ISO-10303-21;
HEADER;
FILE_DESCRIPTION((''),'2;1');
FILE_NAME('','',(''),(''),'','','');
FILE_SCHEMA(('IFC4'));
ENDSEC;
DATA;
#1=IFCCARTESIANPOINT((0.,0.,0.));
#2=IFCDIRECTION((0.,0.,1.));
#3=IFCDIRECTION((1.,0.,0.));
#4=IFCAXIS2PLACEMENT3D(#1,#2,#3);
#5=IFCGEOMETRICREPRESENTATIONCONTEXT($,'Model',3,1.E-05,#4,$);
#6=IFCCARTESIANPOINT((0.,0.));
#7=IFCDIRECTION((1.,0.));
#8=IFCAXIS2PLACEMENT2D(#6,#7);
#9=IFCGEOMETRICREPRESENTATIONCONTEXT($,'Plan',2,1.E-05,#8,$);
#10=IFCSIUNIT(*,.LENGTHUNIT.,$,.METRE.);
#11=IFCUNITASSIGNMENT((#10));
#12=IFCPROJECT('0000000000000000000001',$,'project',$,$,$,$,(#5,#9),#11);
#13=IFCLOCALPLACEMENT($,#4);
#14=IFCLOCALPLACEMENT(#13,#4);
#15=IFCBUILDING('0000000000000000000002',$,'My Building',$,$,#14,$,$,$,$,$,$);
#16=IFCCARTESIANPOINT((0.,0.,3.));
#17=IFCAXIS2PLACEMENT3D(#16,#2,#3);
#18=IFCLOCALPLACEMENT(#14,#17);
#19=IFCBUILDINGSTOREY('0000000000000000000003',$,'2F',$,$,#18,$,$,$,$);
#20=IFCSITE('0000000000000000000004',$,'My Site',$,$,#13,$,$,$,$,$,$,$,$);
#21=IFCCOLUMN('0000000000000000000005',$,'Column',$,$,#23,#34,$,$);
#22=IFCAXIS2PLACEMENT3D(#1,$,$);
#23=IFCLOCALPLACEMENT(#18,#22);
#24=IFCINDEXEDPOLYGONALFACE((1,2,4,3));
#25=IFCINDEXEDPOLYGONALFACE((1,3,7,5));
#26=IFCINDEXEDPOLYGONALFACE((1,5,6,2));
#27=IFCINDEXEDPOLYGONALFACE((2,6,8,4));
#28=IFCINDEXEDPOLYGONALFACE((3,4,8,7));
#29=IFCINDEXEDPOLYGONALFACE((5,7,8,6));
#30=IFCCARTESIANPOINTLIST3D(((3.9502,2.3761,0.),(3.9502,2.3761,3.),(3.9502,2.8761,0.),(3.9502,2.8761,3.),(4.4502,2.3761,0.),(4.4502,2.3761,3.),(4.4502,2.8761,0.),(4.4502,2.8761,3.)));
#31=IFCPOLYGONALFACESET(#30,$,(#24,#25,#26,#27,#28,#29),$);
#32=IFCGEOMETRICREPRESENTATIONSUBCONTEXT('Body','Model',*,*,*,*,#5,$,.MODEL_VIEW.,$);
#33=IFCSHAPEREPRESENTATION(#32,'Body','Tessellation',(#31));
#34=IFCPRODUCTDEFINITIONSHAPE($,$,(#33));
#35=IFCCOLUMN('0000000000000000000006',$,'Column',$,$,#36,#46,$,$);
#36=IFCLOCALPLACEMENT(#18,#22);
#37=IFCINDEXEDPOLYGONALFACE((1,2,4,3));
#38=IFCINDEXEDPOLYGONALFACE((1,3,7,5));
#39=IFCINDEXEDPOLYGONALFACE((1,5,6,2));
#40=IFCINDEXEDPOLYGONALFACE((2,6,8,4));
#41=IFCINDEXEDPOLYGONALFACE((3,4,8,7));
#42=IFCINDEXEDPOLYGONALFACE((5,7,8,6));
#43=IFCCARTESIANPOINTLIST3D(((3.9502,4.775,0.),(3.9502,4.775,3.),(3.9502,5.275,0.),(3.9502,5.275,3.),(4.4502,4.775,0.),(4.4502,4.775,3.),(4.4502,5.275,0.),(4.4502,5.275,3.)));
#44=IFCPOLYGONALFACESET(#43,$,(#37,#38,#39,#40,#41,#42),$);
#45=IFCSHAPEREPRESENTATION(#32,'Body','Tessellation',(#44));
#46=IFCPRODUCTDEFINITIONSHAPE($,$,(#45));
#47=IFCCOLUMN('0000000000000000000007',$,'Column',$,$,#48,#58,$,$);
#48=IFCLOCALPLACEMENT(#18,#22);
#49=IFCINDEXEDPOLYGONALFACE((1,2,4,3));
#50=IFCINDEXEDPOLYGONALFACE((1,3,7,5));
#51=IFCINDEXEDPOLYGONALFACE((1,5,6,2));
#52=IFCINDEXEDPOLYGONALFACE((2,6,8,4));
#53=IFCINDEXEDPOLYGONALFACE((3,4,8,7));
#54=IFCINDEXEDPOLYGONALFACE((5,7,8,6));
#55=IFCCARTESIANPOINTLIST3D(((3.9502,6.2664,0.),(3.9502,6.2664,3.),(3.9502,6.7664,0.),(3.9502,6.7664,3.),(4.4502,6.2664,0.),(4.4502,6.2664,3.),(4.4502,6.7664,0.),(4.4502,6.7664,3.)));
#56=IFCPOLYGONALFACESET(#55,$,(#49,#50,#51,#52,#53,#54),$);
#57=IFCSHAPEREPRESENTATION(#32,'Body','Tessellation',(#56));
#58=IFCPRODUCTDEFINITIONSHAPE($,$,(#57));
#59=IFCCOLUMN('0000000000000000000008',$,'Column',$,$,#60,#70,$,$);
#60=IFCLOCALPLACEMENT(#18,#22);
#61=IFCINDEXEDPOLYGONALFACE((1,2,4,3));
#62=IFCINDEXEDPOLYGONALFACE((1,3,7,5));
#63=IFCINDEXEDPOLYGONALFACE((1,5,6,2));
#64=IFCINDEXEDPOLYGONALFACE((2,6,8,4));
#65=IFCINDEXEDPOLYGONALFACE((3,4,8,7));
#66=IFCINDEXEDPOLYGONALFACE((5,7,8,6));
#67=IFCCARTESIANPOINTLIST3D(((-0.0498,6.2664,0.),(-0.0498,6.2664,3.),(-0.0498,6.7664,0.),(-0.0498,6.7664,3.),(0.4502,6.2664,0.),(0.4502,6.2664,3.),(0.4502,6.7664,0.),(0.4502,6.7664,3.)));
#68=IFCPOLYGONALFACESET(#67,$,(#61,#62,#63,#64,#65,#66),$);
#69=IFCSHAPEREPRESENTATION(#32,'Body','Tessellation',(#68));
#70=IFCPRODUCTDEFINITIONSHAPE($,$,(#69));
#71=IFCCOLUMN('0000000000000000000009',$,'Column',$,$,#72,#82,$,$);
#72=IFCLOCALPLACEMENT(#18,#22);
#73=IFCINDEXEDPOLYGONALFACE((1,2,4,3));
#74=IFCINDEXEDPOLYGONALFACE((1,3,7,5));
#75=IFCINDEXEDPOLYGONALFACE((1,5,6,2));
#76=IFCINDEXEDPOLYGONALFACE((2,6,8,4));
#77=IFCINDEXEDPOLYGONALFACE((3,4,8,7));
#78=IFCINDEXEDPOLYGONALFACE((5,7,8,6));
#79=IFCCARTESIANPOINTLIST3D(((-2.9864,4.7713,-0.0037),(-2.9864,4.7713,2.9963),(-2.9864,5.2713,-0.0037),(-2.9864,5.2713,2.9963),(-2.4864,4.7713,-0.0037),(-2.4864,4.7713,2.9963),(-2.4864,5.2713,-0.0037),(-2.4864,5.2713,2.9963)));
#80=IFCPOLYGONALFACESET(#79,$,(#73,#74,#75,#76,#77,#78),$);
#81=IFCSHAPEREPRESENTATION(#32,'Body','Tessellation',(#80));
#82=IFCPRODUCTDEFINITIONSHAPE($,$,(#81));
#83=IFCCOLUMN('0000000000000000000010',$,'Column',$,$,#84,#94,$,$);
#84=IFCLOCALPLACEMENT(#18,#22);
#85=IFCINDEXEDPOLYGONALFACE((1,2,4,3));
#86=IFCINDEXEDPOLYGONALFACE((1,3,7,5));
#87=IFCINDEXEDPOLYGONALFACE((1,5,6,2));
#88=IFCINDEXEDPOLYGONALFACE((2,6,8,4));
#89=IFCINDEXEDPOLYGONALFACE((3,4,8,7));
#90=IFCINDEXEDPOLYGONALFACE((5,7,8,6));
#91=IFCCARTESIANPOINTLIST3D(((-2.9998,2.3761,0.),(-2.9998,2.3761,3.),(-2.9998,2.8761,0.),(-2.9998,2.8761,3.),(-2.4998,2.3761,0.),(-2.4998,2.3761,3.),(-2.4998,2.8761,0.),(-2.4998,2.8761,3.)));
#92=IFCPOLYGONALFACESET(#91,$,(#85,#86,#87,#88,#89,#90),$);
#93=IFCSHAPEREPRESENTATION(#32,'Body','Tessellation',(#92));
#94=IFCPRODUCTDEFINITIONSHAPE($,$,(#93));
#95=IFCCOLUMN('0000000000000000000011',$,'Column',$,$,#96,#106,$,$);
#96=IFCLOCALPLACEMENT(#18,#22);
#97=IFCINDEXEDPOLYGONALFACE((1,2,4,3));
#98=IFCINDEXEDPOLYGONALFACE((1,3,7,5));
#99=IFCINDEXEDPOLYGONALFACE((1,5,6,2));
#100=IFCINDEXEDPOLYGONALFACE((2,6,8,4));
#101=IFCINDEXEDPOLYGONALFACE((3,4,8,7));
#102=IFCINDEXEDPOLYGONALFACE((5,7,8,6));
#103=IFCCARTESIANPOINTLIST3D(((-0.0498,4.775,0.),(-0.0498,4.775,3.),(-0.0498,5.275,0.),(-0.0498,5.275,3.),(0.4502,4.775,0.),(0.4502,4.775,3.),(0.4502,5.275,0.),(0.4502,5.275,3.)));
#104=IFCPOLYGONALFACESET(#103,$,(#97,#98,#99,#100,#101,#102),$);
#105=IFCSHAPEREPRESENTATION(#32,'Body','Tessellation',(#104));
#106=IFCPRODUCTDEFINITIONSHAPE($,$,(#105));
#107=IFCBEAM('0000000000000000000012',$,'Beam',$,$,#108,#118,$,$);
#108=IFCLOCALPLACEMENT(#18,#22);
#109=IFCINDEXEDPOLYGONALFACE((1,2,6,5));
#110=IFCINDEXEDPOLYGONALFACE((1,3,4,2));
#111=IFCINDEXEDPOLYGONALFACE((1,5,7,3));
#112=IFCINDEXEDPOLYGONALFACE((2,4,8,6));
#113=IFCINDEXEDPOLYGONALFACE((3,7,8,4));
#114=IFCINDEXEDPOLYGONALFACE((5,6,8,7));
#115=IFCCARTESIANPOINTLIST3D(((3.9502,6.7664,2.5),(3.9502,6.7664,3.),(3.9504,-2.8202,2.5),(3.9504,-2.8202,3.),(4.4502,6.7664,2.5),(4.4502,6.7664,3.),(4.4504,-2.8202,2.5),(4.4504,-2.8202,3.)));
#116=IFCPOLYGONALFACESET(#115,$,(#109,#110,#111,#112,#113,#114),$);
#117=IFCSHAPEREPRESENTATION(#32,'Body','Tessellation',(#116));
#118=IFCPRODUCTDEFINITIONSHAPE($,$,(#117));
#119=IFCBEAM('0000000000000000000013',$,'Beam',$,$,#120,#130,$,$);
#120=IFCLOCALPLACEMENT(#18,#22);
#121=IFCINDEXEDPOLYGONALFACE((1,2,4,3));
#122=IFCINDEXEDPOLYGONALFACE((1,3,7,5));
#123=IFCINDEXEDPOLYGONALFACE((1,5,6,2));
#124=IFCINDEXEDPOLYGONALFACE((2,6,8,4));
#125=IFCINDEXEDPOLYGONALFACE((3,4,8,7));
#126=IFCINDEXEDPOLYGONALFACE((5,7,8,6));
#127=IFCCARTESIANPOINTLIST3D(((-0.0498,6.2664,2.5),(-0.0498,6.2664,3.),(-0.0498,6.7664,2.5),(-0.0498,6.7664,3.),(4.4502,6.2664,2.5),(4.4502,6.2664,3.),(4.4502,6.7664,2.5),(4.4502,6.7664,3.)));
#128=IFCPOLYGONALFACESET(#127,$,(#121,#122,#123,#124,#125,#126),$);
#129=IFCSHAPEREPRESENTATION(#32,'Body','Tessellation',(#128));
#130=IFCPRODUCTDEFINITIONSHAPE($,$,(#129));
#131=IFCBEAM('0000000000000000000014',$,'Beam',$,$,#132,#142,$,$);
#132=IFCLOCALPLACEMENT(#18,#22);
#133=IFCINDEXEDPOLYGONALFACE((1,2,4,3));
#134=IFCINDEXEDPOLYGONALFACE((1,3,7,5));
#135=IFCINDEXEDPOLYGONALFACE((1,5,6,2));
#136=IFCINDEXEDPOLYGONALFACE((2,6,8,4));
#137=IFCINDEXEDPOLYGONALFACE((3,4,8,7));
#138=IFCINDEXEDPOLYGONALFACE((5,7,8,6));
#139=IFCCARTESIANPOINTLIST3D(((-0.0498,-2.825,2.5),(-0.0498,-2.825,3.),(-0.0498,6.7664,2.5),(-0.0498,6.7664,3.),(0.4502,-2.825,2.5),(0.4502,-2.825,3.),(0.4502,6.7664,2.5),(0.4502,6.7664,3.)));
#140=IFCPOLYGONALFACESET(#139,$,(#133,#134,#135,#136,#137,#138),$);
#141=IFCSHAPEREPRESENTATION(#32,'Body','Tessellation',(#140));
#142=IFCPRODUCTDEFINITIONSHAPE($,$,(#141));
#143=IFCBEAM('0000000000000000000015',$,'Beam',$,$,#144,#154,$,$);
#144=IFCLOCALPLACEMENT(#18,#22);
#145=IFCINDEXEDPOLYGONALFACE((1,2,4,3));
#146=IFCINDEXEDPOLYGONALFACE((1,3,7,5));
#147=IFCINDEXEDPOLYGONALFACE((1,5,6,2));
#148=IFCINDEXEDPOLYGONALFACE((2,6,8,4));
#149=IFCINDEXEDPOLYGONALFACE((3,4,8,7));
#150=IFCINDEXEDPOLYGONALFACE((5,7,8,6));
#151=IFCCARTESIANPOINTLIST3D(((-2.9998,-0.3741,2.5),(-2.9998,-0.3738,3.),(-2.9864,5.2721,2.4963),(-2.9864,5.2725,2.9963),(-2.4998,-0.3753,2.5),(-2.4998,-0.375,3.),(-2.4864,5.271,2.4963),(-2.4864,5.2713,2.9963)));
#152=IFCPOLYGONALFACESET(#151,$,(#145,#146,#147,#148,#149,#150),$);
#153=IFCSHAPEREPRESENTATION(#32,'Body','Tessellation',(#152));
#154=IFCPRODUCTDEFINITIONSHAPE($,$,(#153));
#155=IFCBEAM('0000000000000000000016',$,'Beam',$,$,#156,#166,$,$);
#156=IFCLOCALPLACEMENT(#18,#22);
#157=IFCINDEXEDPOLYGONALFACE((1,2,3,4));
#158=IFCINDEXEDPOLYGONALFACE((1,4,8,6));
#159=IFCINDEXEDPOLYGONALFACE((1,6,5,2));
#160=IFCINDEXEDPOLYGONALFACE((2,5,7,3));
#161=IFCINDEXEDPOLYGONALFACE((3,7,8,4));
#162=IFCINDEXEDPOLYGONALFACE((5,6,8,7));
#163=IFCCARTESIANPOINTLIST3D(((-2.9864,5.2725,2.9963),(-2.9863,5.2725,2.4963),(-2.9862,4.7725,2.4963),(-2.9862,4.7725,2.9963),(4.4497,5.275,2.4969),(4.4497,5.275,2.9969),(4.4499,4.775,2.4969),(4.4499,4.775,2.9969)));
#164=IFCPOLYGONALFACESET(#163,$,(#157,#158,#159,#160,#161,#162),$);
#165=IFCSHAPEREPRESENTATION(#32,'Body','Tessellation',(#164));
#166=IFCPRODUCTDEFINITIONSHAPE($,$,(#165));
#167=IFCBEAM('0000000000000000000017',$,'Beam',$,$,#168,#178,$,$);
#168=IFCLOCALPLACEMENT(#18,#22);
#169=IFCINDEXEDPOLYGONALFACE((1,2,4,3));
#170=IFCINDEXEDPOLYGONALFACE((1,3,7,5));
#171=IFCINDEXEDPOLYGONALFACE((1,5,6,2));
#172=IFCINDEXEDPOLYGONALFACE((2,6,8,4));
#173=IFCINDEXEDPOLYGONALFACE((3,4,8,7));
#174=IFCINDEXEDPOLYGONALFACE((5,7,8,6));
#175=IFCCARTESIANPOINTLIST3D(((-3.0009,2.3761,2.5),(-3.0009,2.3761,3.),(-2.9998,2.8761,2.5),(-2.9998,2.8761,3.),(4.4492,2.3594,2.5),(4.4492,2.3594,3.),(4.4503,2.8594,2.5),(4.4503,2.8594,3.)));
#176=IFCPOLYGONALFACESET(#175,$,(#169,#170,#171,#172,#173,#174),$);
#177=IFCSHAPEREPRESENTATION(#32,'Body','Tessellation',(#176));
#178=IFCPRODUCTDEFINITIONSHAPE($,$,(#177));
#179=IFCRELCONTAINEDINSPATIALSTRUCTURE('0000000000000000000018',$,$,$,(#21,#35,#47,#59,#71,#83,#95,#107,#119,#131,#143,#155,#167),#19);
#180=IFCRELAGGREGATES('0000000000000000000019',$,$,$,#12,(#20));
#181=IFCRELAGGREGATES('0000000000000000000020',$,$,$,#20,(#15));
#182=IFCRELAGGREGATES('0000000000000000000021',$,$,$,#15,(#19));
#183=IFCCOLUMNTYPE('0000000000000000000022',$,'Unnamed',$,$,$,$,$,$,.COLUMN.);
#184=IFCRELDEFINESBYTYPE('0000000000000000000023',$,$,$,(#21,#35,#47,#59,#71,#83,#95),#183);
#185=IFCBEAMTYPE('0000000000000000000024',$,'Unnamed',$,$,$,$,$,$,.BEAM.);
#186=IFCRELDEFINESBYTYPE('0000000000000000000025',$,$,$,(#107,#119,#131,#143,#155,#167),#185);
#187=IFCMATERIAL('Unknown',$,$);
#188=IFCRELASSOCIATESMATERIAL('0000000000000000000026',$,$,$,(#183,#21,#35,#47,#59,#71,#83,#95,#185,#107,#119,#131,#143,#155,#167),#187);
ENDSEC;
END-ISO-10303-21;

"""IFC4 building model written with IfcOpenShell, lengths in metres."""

from ifc_helpers import new_model, si_unit, frame, origin_with_axes, origin_2d_with_axis, place, context, subcontext, project, spatial, rectangle, extrude, material, material_profile, profile_set, profile_usage, type_object, element, save


model = new_model("IFC4")

# Units and contexts
model_context = context("Model", 3, precision=1e-05, world=origin_with_axes())
plan_context = context("Plan", 2, precision=1e-05, world=origin_2d_with_axis())
body_context_1 = subcontext(model_context, "Body", "Model", "MODEL_VIEW")
ifc_project = project(units=[si_unit("LENGTHUNIT", "METRE")], contexts=[model_context, plan_context])

# Site, building, storey
site_placement = place(None, origin_with_axes())
site = spatial("IfcSite", under=ifc_project, at=site_placement, Name="My Site")
building_placement = place(site_placement, origin_with_axes())
building = spatial("IfcBuilding", under=site, at=building_placement, Name="My Building")
storey_placement = place(building_placement, frame((0.0, 0.0, 3.0), z_axis=(0.0, 0.0, 1.0), x_axis=(1.0, 0.0, 0.0)))
storey = spatial("IfcBuildingStorey", under=building, at=storey_placement, Name="2F")

# Columns
ifc_material = material(Name="Unknown")
ifc_material_profile_1 = material_profile(ifc_material, rectangle(XDim=0.5, YDim=0.5))
ifc_profile_set_1 = profile_set([ifc_material_profile_1])
ifc_profile_usage_1 = profile_usage(ifc_profile_set_1, cardinal=7)
column_type = type_object("IfcColumnType", Name="Unnamed", PredefinedType="COLUMN", material=ifc_profile_set_1)
column_1_placement = place(storey_placement, frame((4.4502, 2.8761, 0.0), z_axis=(0.0, 0.0, 1.0), x_axis=(1.0, 0.0, 0.0)))
element("IfcColumn", 1, at=column_1_placement, inside=storey, type_object=column_type, material=ifc_profile_usage_1, Name="Column", context=body_context_1, shape_type="SweptSolid", body=[
    extrude(rectangle(XDim=0.5, YDim=0.5), frame((-0.25, -0.25, 0.0), z_axis=(0.0, 0.0, 1.0), x_axis=(1.0, 0.0, 0.0)), (0.0, 0.0, 1.0), 3.0),
])
ifc_profile_usage_2 = profile_usage(ifc_profile_set_1, cardinal=7)
column_2_placement = place(storey_placement, frame((4.4502, 5.275, 0.0), z_axis=(0.0, 0.0, 1.0), x_axis=(1.0, 0.0, 0.0)))
element("IfcColumn", 2, at=column_2_placement, inside=storey, type_object=column_type, material=ifc_profile_usage_2, Name="Column", context=body_context_1, shape_type="SweptSolid", body=[
    extrude(rectangle(XDim=0.5, YDim=0.5), frame((-0.25, -0.25, 0.0), z_axis=(0.0, 0.0, 1.0), x_axis=(1.0, 0.0, 0.0)), (0.0, 0.0, 1.0), 3.0),
])
ifc_profile_usage_3 = profile_usage(ifc_profile_set_1, cardinal=7)
column_3_placement = place(storey_placement, frame((3.9502, 6.7664, 3.0), z_axis=(0.0, 0.0, -1.0), x_axis=(-1.0, 0.0, 0.0)))
element("IfcColumn", 3, at=column_3_placement, inside=storey, type_object=column_type, material=ifc_profile_usage_3, Name="Column", context=body_context_1, shape_type="SweptSolid", body=[
    extrude(rectangle(XDim=0.5, YDim=0.5), frame((-0.25, -0.25, 0.0), z_axis=(0.0, 0.0, 1.0), x_axis=(1.0, 0.0, 0.0)), (0.0, 0.0, 1.0), 3.0),
])
ifc_profile_usage_4 = profile_usage(ifc_profile_set_1, cardinal=7)
column_4_placement = place(storey_placement, frame((0.4502, 6.7664, 0.0), z_axis=(0.0, 0.0, 1.0), x_axis=(1.0, 0.0, 0.0)))
element("IfcColumn", 4, at=column_4_placement, inside=storey, type_object=column_type, material=ifc_profile_usage_4, Name="Column", context=body_context_1, shape_type="SweptSolid", body=[
    extrude(rectangle(XDim=0.5, YDim=0.5), frame((-0.25, -0.25, 0.0), z_axis=(0.0, 0.0, 1.0), x_axis=(1.0, 0.0, 0.0)), (0.0, 0.0, 1.0), 3.0),
])
ifc_profile_usage_5 = profile_usage(ifc_profile_set_1, cardinal=7)
column_5_placement = place(storey_placement, frame((-2.4864, 5.2713, -0.0037), z_axis=(0.0, 0.0, 1.0), x_axis=(1.0, 0.0, 0.0)))
element("IfcColumn", 5, at=column_5_placement, inside=storey, type_object=column_type, material=ifc_profile_usage_5, Name="Column", context=body_context_1, shape_type="SweptSolid", body=[
    extrude(rectangle(XDim=0.5, YDim=0.5), frame((-0.25, -0.25, 0.0), z_axis=(0.0, 0.0, 1.0), x_axis=(1.0, 0.0, 0.0)), (0.0, 0.0, 1.0), 3.0),
])
ifc_profile_usage_6 = profile_usage(ifc_profile_set_1, cardinal=7)
column_6_placement = place(storey_placement, frame((-2.4998, 2.8761, 0.0), z_axis=(0.0, 0.0, 1.0), x_axis=(1.0, 0.0, 0.0)))
element("IfcColumn", 6, at=column_6_placement, inside=storey, type_object=column_type, material=ifc_profile_usage_6, Name="Column", context=body_context_1, shape_type="SweptSolid", body=[
    extrude(rectangle(XDim=0.5, YDim=0.5), frame((-0.25, -0.25, 0.0), z_axis=(0.0, 0.0, 1.0), x_axis=(1.0, 0.0, 0.0)), (0.0, 0.0, 1.0), 3.0),
])
ifc_profile_usage_7 = profile_usage(ifc_profile_set_1, cardinal=7)
column_7_placement = place(storey_placement, frame((0.4502, 5.275, 0.0), z_axis=(0.0, 0.0, 1.0), x_axis=(1.0, 0.0, 0.0)))
element("IfcColumn", 7, at=column_7_placement, inside=storey, type_object=column_type, material=ifc_profile_usage_7, Name="Column", context=body_context_1, shape_type="SweptSolid", body=[
    extrude(rectangle(XDim=0.5, YDim=0.5), frame((-0.25, -0.25, 0.0), z_axis=(0.0, 0.0, 1.0), x_axis=(1.0, 0.0, 0.0)), (0.0, 0.0, 1.0), 3.0),
])

# Beams
ifc_material_profile_2 = material_profile(ifc_material, rectangle(XDim=0.5, YDim=0.5))
ifc_profile_set_2 = profile_set([ifc_material_profile_2])
ifc_profile_usage_8 = profile_usage(ifc_profile_set_2, cardinal=7)
beam_type = type_object("IfcBeamType", Name="Unnamed", PredefinedType="BEAM", material=ifc_profile_set_2)
beam_1_placement = place(storey_placement, frame((4.4502, 6.7664, 3.0), z_axis=(0.000022, -1.0, 0.0), x_axis=(1.0, 0.000022, 0.0)))
element("IfcBeam", 8, at=beam_1_placement, inside=storey, type_object=beam_type, material=ifc_profile_usage_8, Name="Beam", context=body_context_1, shape_type="SweptSolid", body=[
    extrude(rectangle(XDim=0.5, YDim=0.5), frame((-0.25, -0.25, 0.0), z_axis=(0.0, 0.0, 1.0), x_axis=(1.0, 0.0, 0.0)), (0.0, 0.0, 1.0), 9.5866),
])
ifc_profile_usage_9 = profile_usage(ifc_profile_set_2, cardinal=7)
beam_2_placement = place(storey_placement, frame((4.4502, 6.2664, 3.0), z_axis=(-1.0, 0.0, 0.0), x_axis=(0.0, -1.0, 0.0)))
element("IfcBeam", 9, at=beam_2_placement, inside=storey, type_object=beam_type, material=ifc_profile_usage_9, Name="Beam", context=body_context_1, shape_type="SweptSolid", body=[
    extrude(rectangle(XDim=0.5, YDim=0.5), frame((-0.25, -0.25, 0.0), z_axis=(0.0, 0.0, 1.0), x_axis=(1.0, 0.0, 0.0)), (0.0, 0.0, 1.0), 4.5),
])
ifc_profile_usage_10 = profile_usage(ifc_profile_set_2, cardinal=7)
beam_3_placement = place(storey_placement, frame((0.4502, 6.7664, 3.0), z_axis=(0.0, -1.0, 0.0), x_axis=(1.0, 0.0, 0.0)))
element("IfcBeam", 10, at=beam_3_placement, inside=storey, type_object=beam_type, material=ifc_profile_usage_10, Name="Beam", context=body_context_1, shape_type="SweptSolid", body=[
    extrude(rectangle(XDim=0.5, YDim=0.5), frame((-0.25, -0.25, 0.0), z_axis=(0.0, 0.0, 1.0), x_axis=(1.0, 0.0, 0.0)), (0.0, 0.0, 1.0), 9.5914),
])
ifc_profile_usage_11 = profile_usage(ifc_profile_set_2, cardinal=7)
beam_4_placement = place(storey_placement, frame((-2.4864, 5.2713, 2.9963), z_axis=(-0.002376, -0.999997, 0.000657), x_axis=(0.999997, -0.002376, 0.0)))
element("IfcBeam", 11, at=beam_4_placement, inside=storey, type_object=beam_type, material=ifc_profile_usage_11, Name="Beam", context=body_context_1, shape_type="SweptSolid", body=[
    extrude(rectangle(XDim=0.5, YDim=0.5), frame((-0.25, -0.25, 0.0), z_axis=(0.0, 0.0, 1.0), x_axis=(1.0, 0.0, 0.0)), (0.0, 0.0, 1.0), 5.6463),
])
ifc_profile_usage_12 = profile_usage(ifc_profile_set_2, cardinal=7)
beam_5_placement = place(storey_placement, frame((-2.9864, 5.2725, 2.9963), z_axis=(1.0, 0.000339, 0.00008), x_axis=(-0.000339, 1.0, 0.0)))
element("IfcBeam", 12, at=beam_5_placement, inside=storey, type_object=beam_type, material=ifc_profile_usage_12, Name="Beam", context=body_context_1, shape_type="SweptSolid", body=[
    extrude(rectangle(XDim=0.5, YDim=0.5), frame((-0.25, -0.25, 0.0), z_axis=(0.0, 0.0, 1.0), x_axis=(1.0, 0.0, 0.0)), (0.0, 0.0, 1.0), 7.4361),
])
ifc_profile_usage_13 = profile_usage(ifc_profile_set_2, cardinal=7)
beam_6_placement = place(storey_placement, frame((-2.9998, 2.8761, 3.0), z_axis=(0.999997, -0.002245, 0.0), x_axis=(0.002245, 0.999997, 0.0)))
element("IfcBeam", 13, at=beam_6_placement, inside=storey, type_object=beam_type, material=ifc_profile_usage_13, Name="Beam", context=body_context_1, shape_type="SweptSolid", body=[
    extrude(rectangle(XDim=0.5, YDim=0.5), frame((-0.25, -0.25, 0.0), z_axis=(0.0, 0.0, 1.0), x_axis=(1.0, 0.0, 0.0)), (0.0, 0.0, 1.0), 7.4501),
])

save(model, "model.ifc")
